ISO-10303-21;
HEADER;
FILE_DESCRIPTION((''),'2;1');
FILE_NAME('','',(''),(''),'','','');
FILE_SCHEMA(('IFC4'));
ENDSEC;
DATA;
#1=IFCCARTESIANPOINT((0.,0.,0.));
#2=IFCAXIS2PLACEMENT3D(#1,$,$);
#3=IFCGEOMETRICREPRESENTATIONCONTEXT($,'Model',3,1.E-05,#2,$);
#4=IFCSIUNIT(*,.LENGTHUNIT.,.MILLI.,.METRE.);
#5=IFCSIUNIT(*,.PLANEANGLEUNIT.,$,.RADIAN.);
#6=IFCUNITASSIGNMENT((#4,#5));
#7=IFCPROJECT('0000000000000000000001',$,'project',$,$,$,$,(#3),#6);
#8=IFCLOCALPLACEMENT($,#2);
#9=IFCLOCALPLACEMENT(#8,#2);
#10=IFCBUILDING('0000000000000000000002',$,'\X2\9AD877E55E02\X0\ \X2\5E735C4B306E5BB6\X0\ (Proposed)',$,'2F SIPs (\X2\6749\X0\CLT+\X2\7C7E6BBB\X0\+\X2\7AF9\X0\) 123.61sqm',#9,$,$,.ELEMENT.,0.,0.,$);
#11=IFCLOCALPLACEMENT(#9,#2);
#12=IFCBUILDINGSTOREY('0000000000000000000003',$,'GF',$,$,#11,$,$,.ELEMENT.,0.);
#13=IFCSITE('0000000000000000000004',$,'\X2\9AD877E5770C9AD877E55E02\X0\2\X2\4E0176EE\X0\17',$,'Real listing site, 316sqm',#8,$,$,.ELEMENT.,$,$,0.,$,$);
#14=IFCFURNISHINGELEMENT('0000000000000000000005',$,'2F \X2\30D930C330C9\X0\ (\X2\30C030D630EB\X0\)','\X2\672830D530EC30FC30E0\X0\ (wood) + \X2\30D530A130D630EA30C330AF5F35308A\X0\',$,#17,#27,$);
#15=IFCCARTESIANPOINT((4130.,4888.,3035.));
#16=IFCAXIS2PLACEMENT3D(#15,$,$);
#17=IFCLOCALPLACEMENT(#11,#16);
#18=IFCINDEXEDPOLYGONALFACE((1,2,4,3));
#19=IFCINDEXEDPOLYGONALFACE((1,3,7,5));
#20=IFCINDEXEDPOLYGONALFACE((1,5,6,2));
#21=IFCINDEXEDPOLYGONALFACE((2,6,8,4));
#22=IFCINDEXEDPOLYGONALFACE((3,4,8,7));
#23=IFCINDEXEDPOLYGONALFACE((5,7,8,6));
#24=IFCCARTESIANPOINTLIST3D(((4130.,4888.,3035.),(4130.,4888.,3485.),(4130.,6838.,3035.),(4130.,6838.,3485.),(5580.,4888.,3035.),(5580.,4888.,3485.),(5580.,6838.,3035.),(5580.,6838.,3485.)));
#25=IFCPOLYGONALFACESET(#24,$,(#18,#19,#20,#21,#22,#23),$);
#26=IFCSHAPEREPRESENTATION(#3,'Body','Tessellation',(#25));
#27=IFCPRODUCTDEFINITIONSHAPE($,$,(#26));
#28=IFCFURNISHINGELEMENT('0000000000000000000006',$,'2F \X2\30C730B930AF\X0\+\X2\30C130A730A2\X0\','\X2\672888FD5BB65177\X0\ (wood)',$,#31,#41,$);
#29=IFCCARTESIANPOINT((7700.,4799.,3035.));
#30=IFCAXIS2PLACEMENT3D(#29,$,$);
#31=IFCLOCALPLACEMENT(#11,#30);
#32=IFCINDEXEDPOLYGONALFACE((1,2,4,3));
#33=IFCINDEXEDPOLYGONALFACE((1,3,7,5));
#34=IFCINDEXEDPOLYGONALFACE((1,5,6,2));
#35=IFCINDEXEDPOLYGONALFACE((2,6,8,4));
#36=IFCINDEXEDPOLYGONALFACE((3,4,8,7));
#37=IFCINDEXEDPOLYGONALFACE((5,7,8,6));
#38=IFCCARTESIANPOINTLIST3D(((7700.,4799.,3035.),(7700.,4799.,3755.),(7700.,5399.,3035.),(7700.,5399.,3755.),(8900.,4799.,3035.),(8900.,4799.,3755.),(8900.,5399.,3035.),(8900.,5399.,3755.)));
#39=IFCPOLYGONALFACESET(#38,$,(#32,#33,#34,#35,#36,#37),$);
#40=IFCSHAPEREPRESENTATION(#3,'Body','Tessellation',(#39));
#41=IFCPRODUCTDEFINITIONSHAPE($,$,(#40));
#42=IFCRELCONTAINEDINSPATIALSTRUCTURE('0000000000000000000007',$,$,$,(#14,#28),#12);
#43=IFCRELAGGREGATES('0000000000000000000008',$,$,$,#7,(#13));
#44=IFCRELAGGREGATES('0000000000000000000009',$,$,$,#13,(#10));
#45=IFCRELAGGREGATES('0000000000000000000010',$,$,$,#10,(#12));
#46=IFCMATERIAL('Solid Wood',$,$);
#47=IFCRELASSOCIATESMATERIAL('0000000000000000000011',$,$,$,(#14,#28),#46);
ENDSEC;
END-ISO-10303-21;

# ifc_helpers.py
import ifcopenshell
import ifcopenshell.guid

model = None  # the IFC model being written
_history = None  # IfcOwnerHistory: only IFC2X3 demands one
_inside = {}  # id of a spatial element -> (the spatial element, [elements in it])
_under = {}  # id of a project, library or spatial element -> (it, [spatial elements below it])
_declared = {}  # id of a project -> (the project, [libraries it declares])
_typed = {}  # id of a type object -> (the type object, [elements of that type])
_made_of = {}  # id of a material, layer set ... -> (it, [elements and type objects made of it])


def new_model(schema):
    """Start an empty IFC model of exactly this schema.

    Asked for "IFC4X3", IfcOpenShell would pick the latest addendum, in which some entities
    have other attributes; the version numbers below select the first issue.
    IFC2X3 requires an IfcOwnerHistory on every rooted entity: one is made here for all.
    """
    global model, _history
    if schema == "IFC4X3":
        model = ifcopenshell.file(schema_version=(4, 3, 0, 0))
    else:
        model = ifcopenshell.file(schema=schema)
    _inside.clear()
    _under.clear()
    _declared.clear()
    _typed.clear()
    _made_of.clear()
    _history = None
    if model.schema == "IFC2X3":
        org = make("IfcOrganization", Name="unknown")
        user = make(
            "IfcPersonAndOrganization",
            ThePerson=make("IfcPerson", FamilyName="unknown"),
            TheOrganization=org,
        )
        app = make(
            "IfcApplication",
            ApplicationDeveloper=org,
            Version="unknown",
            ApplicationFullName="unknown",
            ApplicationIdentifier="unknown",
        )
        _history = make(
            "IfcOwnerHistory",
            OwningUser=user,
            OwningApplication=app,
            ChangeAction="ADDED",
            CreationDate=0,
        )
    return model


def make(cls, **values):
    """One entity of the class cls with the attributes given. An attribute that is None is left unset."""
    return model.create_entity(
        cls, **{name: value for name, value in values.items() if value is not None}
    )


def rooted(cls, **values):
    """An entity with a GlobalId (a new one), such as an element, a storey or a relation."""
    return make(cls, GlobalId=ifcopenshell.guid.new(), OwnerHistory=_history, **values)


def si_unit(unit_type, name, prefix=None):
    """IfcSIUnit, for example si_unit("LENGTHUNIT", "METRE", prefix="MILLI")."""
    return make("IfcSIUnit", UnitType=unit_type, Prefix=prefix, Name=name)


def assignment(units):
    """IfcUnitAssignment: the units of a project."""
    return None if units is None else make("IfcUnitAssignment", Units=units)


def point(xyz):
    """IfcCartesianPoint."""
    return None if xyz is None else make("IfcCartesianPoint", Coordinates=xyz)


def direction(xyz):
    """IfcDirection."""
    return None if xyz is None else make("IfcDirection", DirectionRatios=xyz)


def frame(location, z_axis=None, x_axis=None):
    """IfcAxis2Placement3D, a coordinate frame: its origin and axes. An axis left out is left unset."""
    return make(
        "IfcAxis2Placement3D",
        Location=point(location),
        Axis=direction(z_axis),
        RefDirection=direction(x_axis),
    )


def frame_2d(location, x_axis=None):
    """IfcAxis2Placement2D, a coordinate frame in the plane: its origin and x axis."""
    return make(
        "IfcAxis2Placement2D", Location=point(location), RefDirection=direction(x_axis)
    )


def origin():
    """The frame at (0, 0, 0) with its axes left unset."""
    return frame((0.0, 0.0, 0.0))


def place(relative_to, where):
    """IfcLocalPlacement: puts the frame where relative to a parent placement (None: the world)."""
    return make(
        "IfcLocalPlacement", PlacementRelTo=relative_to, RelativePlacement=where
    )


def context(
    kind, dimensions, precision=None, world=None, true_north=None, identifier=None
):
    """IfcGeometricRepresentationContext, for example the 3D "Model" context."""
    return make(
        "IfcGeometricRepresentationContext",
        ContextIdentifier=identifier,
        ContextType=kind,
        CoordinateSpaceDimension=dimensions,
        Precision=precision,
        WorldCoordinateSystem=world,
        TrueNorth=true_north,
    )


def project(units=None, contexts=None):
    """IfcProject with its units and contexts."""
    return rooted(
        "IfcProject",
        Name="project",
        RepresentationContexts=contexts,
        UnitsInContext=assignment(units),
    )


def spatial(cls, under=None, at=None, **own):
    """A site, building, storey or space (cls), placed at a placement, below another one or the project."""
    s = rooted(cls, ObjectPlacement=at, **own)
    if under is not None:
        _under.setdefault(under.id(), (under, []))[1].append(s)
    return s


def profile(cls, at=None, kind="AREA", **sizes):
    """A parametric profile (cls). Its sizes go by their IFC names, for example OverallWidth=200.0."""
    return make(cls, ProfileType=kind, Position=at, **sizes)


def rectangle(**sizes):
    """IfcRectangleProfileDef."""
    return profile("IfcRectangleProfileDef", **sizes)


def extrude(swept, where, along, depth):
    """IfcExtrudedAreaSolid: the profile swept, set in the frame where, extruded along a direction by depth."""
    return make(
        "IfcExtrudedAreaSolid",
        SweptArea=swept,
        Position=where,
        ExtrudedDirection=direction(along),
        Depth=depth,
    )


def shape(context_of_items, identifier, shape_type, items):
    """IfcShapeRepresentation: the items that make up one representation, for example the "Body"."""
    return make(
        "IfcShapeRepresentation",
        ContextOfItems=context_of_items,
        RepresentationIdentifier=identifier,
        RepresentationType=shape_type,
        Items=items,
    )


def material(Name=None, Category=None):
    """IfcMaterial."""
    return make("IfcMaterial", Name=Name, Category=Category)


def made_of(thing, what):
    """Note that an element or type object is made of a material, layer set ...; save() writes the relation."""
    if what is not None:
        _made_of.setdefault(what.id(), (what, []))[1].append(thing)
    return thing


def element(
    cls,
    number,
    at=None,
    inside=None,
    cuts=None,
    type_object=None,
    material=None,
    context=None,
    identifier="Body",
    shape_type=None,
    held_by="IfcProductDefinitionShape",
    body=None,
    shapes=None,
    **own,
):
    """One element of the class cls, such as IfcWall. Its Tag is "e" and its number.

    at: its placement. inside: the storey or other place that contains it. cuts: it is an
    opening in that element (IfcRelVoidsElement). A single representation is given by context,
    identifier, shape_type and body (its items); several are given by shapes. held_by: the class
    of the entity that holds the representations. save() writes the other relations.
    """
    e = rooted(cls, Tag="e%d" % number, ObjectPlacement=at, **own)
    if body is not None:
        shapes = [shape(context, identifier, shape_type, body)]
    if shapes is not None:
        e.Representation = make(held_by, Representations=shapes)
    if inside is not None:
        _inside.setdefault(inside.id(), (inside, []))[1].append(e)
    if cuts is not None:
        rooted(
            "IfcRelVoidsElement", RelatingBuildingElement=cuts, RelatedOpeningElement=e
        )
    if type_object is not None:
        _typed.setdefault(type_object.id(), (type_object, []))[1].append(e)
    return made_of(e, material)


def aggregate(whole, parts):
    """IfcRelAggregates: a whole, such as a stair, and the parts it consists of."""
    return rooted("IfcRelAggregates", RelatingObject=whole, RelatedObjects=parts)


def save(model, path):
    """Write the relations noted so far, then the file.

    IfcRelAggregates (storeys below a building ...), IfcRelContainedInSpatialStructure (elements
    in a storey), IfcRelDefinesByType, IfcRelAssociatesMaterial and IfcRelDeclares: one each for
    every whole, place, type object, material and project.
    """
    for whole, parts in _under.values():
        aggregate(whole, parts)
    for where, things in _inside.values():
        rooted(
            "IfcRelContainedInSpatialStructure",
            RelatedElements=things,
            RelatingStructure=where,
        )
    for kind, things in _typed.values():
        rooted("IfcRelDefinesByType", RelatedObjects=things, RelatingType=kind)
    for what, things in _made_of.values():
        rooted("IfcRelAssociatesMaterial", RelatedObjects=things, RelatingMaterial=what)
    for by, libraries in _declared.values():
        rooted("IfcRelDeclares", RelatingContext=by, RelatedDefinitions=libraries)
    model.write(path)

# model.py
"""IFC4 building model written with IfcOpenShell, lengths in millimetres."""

from ifc_helpers import new_model, si_unit, frame, frame_2d, origin, place, context, project, spatial, rectangle, extrude, material, element, save


model = new_model("IFC4")

# Units and contexts
model_context = context("Model", 3, precision=1e-05, world=origin())
ifc_project = project(units=[si_unit("LENGTHUNIT", "METRE", prefix="MILLI"), si_unit("PLANEANGLEUNIT", "RADIAN")], contexts=[model_context])

# Site, building, storey
site_placement = place(None, origin())
site = spatial("IfcSite", under=ifc_project, at=site_placement, Name="高知県高知市2丁目17", ObjectType="Real listing site, 316sqm", CompositionType="ELEMENT", RefElevation=0.0)
building_placement = place(site_placement, origin())
building = spatial("IfcBuilding", under=site, at=building_placement, Name="高知市 平屋の家 (Proposed)", ObjectType="2F SIPs (杉CLT+籾殻+竹) 123.61sqm", CompositionType="ELEMENT", ElevationOfRefHeight=0.0, ElevationOfTerrain=0.0)
storey_placement = place(building_placement, origin())
storey = spatial("IfcBuildingStorey", under=building, at=storey_placement, Name="GF", CompositionType="ELEMENT", Elevation=0.0)

# Shared definitions
ifc_material_1 = material(Name="Solid Wood")

# Furnishing elements
furnishing_1_placement = place(storey_placement, frame((4130.0, 4888.0, 3035.0)))
element("IfcFurnishingElement", 1, at=furnishing_1_placement, inside=storey, material=ifc_material_1, Name="2F ベッド (ダブル)", Description="木フレーム (wood) + ファブリック張り", context=model_context, shape_type="SweptSolid", body=[
    extrude(rectangle(XDim=1450.0, YDim=1950.0, at=frame_2d((725.0, 975.0))), frame((4130.0, 4888.0, 3035.0)), (0.0, 0.0, 1.0), 450.0),
])
furnishing_2_placement = place(storey_placement, frame((7700.0, 4799.0, 3035.0)))
element("IfcFurnishingElement", 2, at=furnishing_2_placement, inside=storey, material=ifc_material_1, Name="2F デスク+チェア", Description="木製家具 (wood)", context=model_context, shape_type="SweptSolid", body=[
    extrude(rectangle(XDim=1200.0, YDim=600.0, at=frame_2d((600.0, 300.0))), frame((7700.0, 4799.0, 3035.0)), (0.0, 0.0, 1.0), 720.0),
])

save(model, "model.ifc")
